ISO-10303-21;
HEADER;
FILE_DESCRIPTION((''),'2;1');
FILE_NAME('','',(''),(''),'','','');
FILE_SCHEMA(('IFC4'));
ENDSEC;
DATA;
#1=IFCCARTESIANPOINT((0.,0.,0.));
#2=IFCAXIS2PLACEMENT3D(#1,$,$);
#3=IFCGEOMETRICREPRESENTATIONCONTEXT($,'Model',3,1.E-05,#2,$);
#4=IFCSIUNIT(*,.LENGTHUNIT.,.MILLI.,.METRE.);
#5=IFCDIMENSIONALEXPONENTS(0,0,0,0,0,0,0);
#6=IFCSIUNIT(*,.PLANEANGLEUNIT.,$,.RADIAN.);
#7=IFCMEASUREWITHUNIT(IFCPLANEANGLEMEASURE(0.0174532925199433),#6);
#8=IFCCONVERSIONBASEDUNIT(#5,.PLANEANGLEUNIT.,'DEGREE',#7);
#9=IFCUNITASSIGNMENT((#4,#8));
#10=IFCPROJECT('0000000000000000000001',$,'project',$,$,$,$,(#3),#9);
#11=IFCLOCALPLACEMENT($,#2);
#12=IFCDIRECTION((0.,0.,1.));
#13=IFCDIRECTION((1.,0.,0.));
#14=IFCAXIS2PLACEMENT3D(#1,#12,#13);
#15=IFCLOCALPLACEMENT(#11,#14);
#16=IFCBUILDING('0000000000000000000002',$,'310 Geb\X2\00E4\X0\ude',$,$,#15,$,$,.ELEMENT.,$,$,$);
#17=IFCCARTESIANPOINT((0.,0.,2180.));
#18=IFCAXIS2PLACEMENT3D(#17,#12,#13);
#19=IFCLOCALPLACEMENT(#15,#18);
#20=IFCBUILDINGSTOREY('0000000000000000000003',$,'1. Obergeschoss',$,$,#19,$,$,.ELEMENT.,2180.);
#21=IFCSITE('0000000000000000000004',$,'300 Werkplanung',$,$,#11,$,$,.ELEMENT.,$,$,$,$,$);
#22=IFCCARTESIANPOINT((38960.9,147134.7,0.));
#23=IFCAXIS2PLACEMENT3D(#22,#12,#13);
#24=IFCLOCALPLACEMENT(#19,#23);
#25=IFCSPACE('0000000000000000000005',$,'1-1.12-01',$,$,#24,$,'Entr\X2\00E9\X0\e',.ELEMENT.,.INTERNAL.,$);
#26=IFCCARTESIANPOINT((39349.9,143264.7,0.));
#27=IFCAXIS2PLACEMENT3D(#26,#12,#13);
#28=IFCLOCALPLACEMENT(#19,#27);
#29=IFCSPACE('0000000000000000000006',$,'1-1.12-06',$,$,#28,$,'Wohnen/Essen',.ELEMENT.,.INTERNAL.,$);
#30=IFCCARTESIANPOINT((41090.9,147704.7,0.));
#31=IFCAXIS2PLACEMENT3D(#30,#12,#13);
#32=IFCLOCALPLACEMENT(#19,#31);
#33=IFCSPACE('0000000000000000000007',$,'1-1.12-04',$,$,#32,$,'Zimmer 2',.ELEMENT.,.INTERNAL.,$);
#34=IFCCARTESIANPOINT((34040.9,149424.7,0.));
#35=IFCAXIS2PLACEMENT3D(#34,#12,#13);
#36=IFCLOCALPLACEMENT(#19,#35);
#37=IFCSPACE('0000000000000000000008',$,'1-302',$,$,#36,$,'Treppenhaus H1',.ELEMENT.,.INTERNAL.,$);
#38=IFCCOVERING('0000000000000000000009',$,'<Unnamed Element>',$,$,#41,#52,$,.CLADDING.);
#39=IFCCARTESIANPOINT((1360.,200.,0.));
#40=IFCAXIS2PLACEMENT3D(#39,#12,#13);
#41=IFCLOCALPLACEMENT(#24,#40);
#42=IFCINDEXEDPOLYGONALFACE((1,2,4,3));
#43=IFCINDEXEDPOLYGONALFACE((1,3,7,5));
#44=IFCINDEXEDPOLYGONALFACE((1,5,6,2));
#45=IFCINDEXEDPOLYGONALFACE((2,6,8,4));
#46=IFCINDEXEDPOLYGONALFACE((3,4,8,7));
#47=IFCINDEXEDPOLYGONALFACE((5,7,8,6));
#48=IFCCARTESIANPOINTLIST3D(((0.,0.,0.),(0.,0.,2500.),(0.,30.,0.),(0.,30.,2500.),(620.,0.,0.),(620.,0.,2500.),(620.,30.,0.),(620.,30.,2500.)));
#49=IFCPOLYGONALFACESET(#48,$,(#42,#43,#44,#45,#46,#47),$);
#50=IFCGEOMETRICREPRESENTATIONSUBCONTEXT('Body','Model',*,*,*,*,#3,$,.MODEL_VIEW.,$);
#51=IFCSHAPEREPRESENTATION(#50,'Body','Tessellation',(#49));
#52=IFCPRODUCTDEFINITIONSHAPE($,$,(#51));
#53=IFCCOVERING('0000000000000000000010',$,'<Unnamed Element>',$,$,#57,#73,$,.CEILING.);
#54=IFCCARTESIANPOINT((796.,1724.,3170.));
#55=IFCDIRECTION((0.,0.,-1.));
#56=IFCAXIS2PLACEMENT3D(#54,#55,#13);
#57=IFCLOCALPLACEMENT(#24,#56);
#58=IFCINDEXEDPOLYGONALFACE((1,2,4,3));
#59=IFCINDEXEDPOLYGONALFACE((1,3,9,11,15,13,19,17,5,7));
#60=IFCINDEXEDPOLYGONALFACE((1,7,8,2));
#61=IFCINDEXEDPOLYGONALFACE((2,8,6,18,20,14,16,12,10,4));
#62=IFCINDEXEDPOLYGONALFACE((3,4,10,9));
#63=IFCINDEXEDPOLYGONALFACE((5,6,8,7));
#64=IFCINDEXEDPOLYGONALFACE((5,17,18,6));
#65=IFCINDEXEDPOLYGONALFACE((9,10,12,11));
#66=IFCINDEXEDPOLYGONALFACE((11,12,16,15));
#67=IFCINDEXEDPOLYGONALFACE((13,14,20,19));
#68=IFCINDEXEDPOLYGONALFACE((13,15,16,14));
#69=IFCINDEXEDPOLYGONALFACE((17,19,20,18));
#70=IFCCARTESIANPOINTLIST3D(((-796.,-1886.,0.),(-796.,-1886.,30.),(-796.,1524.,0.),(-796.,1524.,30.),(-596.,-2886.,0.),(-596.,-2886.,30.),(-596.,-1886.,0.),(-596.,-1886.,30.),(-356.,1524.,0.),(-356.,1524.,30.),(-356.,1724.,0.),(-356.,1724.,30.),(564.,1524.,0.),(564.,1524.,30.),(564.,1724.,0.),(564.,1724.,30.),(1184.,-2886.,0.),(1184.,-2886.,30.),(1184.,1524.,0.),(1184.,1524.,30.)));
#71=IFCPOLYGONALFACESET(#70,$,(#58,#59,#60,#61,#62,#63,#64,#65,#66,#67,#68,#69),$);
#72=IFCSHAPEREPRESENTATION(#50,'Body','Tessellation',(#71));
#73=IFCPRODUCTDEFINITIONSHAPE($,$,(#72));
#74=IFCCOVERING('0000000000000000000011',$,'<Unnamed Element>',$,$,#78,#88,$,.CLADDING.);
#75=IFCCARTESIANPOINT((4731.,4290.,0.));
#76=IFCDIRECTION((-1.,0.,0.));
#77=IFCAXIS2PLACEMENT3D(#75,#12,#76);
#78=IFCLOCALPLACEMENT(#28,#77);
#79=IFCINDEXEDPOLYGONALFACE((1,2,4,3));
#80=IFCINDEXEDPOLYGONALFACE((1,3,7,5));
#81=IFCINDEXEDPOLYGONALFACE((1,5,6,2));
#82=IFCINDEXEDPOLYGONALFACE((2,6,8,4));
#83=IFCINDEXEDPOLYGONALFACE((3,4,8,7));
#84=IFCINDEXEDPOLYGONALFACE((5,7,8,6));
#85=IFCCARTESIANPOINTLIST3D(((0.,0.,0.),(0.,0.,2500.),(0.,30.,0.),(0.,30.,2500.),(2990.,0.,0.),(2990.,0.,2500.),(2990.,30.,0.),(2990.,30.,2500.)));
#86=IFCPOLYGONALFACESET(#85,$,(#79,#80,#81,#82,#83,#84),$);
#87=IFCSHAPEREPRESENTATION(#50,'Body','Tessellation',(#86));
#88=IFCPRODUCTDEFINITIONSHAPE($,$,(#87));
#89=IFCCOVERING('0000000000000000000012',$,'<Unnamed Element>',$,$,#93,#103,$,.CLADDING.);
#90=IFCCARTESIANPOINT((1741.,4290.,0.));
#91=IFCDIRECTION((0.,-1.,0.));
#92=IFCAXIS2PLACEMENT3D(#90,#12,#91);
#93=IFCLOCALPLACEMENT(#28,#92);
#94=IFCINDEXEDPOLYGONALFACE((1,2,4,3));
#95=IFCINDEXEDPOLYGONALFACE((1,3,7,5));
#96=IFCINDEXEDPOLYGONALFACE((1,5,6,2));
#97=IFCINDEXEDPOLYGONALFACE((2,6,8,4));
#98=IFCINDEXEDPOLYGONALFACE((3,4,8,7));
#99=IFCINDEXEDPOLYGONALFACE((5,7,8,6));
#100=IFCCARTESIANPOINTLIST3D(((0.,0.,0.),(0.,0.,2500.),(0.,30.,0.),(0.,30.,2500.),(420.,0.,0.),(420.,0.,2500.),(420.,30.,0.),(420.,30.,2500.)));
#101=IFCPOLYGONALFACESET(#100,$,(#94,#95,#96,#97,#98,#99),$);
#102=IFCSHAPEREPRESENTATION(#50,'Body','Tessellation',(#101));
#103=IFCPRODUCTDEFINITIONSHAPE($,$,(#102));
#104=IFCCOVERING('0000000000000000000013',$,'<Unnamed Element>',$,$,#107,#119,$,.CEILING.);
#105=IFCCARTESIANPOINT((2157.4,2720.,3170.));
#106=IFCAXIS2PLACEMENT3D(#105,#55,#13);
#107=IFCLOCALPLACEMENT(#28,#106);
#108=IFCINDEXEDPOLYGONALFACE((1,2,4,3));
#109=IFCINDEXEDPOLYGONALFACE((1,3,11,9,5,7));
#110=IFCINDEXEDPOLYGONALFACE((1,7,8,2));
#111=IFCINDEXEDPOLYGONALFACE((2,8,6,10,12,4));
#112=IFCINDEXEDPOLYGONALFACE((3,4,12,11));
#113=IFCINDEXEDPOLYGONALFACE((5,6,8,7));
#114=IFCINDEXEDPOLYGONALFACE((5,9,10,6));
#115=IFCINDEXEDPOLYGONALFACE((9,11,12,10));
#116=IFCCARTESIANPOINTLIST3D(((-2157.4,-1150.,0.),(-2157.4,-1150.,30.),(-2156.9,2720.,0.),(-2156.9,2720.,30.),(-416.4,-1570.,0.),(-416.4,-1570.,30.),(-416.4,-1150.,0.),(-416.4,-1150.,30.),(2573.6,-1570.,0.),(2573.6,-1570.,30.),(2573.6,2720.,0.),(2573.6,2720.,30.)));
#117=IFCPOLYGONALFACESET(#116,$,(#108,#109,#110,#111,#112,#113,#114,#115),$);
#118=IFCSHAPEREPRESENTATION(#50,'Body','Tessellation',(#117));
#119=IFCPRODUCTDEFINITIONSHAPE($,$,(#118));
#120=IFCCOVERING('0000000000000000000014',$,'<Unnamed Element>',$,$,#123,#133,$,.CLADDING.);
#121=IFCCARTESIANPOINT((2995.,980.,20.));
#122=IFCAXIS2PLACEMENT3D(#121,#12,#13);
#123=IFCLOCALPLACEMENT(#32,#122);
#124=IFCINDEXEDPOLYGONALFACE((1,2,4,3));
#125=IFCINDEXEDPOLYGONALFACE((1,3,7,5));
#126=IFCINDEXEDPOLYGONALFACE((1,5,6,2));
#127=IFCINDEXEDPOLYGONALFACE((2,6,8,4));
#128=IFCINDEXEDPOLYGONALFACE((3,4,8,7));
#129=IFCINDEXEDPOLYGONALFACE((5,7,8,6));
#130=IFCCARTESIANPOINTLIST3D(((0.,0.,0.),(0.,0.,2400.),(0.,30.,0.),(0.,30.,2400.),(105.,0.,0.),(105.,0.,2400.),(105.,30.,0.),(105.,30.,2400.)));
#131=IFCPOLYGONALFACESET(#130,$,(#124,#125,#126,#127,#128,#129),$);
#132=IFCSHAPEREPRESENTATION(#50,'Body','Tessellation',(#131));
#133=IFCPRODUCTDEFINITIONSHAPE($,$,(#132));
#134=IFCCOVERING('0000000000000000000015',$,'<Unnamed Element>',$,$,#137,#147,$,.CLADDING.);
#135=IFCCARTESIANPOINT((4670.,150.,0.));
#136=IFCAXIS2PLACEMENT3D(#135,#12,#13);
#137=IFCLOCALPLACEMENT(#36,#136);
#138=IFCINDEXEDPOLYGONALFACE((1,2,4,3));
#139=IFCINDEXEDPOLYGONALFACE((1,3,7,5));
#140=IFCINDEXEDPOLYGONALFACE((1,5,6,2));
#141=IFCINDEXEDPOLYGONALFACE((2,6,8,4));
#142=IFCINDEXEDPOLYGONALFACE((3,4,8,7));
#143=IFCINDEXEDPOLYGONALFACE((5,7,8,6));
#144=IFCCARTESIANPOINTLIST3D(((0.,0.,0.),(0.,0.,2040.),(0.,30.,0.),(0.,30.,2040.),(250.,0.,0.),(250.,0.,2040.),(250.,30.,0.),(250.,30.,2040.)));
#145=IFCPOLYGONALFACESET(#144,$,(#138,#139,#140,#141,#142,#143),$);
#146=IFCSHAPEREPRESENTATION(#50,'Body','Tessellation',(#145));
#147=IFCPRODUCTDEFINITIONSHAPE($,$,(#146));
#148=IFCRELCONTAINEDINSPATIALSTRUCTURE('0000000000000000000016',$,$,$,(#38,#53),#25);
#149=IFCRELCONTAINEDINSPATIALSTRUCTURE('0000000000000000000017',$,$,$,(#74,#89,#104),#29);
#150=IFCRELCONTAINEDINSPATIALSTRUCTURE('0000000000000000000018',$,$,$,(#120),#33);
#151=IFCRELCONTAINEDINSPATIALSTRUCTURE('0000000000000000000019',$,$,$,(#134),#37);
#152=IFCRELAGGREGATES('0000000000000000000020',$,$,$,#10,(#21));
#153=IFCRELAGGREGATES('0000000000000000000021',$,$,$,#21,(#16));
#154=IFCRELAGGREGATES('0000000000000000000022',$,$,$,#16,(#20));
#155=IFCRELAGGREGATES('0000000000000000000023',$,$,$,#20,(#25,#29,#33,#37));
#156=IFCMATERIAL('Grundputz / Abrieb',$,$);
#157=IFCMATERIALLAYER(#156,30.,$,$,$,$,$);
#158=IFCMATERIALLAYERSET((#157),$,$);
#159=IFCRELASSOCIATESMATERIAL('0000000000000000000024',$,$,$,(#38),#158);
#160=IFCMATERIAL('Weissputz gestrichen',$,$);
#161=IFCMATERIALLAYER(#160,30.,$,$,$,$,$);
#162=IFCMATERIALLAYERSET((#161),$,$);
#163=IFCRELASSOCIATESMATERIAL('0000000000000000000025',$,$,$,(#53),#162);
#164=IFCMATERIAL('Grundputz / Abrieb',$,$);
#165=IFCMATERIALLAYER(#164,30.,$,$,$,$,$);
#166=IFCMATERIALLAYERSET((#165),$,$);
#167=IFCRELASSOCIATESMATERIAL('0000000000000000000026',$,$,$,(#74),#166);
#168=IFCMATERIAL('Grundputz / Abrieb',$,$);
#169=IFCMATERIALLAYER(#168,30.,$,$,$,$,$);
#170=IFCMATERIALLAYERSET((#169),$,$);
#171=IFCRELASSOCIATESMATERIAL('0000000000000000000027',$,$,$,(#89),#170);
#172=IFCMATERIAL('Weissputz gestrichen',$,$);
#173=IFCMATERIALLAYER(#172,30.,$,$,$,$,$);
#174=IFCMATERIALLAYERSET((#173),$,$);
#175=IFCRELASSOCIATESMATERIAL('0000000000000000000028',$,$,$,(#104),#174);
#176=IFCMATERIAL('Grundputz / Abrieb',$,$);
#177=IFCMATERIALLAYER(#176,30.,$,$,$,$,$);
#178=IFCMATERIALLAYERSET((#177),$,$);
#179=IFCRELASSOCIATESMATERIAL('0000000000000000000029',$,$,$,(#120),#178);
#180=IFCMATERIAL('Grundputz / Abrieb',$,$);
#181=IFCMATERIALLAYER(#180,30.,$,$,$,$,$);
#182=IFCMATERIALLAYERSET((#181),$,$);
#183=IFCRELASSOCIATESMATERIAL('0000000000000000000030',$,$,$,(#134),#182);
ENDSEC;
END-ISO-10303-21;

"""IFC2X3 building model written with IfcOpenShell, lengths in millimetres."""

from ifc_helpers import new_model, entity, si_unit, converted_unit, frame, frame_2d, origin, origin_with_axes, place, context, subcontext, project, spatial, polyline, rectangle, outline, extrude, material, layer, layer_set, layer_usage, element, save


model = new_model("IFC2X3")

# Units and contexts
model_context = context("Model", 3, precision=1e-05, world=origin())
body_context = subcontext(model_context, "Body", "Model", "MODEL_VIEW")
ifc_project = project(units=[si_unit("LENGTHUNIT", "METRE", prefix="MILLI"), converted_unit("PLANEANGLEUNIT", "DEGREE", entity("IfcPlaneAngleMeasure", 0.0174532925199433), si_unit("PLANEANGLEUNIT", "RADIAN"), dimensions=[0, 0, 0, 0, 0, 0, 0])], contexts=[model_context])

# Site, building, storey
site_placement = place(None, origin())
site = spatial("IfcSite", under=ifc_project, at=site_placement, Name="300 Werkplanung", CompositionType="ELEMENT")
building_placement = place(site_placement, origin_with_axes())
building = spatial("IfcBuilding", under=site, at=building_placement, Name="310 Gebäude", CompositionType="ELEMENT")
storey_placement = place(building_placement, frame((0.0, 0.0, 2180.0), z_axis=(0.0, 0.0, 1.0), x_axis=(1.0, 0.0, 0.0)))
storey = spatial("IfcBuildingStorey", under=building, at=storey_placement, Name="1. Obergeschoss", CompositionType="ELEMENT", Elevation=2180.0)

# Shared definitions
space_1_placement = place(storey_placement, frame((38960.9, 147134.7, 0.0), z_axis=(0.0, 0.0, 1.0), x_axis=(1.0, 0.0, 0.0)))
space_1 = spatial("IfcSpace", under=storey, at=space_1_placement, Name="1-1.12-01", LongName="Entrée", CompositionType="ELEMENT", InteriorOrExteriorSpace="INTERNAL")

# Coverings
ifc_material_1 = material(Name="Grundputz / Abrieb")
ifc_layer_1 = layer(ifc_material_1, 30.0)
ifc_layer_set_1 = layer_set([ifc_layer_1])
ifc_layer_usage_1 = layer_usage(ifc_layer_set_1, "AXIS3", "POSITIVE", 0.0)
covering_1_placement = place(space_1_placement, frame((1360.0, 200.0, 0.0), z_axis=(0.0, 0.0, 1.0), x_axis=(1.0, 0.0, 0.0)))
element("IfcCovering", 1, at=covering_1_placement, inside=space_1, material=ifc_layer_usage_1, Name="<Unnamed Element>", PredefinedType="CLADDING", context=body_context, shape_type="SweptSolid", body=[
    extrude(rectangle(XDim=2500.0, YDim=620.0, at=frame_2d((-310.0, 1250.0), x_axis=(0.0, 1.0))), frame((620.0, 0.0, 2500.0), z_axis=(0.0, 1.0, 0.0), x_axis=(1.0, 0.0, 0.0)), (0.0, 0.0, 1.0), 30.0),
])
ifc_material_2 = material(Name="Weissputz gestrichen")
ifc_layer_2 = layer(ifc_material_2, 30.0)
ifc_layer_set_2 = layer_set([ifc_layer_2])
ifc_layer_usage_2 = layer_usage(ifc_layer_set_2, "AXIS3", "POSITIVE", 0.0)
covering_2_placement = place(space_1_placement, frame((796.0, 1724.0, 3170.0), z_axis=(0.0, 0.0, -1.0), x_axis=(1.0, 0.0, 0.0)))
element("IfcCovering", 2, at=covering_2_placement, inside=space_1, material=ifc_layer_usage_2, Name="<Unnamed Element>", PredefinedType="CEILING", context=body_context, shape_type="SweptSolid", body=[
    extrude(outline(polyline([(-796.0, 1524.0), (-796.0, -1886.0), (-596.0, -1886.0), (-596.0, -2886.0), (1184.0, -2886.0), (1184.0, 1524.0), (564.0, 1524.0), (564.0, 1724.0), (-356.0, 1724.0), (-356.0, 1524.0), (-796.0, 1524.0)])), origin_with_axes(), (0.0, 0.0, 1.0), 30.0),
])

# Shared definitions
space_2_placement = place(storey_placement, frame((39349.9, 143264.7, 0.0), z_axis=(0.0, 0.0, 1.0), x_axis=(1.0, 0.0, 0.0)))
space_2 = spatial("IfcSpace", under=storey, at=space_2_placement, Name="1-1.12-06", LongName="Wohnen/Essen", CompositionType="ELEMENT", InteriorOrExteriorSpace="INTERNAL")

# Coverings
ifc_material_3 = material(Name="Grundputz / Abrieb")
ifc_layer_3 = layer(ifc_material_3, 30.0)
ifc_layer_set_3 = layer_set([ifc_layer_3])
ifc_layer_usage_3 = layer_usage(ifc_layer_set_3, "AXIS3", "POSITIVE", 0.0)
covering_3_placement = place(space_2_placement, frame((4731.0, 4290.0, 0.0), z_axis=(0.0, 0.0, 1.0), x_axis=(-1.0, 0.0, 0.0)))
element("IfcCovering", 3, at=covering_3_placement, inside=space_2, material=ifc_layer_usage_3, Name="<Unnamed Element>", PredefinedType="CLADDING", context=body_context, shape_type="SweptSolid", body=[
    extrude(rectangle(XDim=2500.0, YDim=2990.0, at=frame_2d((-1495.0, 1250.0), x_axis=(0.0, 1.0))), frame((2990.0, 0.0, 2500.0), z_axis=(0.0, 1.0, 0.0), x_axis=(1.0, 0.0, 0.0)), (0.0, 0.0, 1.0), 30.0),
])
ifc_material_4 = material(Name="Grundputz / Abrieb")
ifc_layer_4 = layer(ifc_material_4, 30.0)
ifc_layer_set_4 = layer_set([ifc_layer_4])
ifc_layer_usage_4 = layer_usage(ifc_layer_set_4, "AXIS3", "POSITIVE", 0.0)
covering_4_placement = place(space_2_placement, frame((1741.0, 4290.0, 0.0), z_axis=(0.0, 0.0, 1.0), x_axis=(0.0, -1.0, 0.0)))
element("IfcCovering", 4, at=covering_4_placement, inside=space_2, material=ifc_layer_usage_4, Name="<Unnamed Element>", PredefinedType="CLADDING", context=body_context, shape_type="SweptSolid", body=[
    extrude(rectangle(XDim=2500.0, YDim=420.0, at=frame_2d((-210.0, 1250.0), x_axis=(0.0, 1.0))), frame((420.0, 0.0, 2500.0), z_axis=(0.0, 1.0, 0.0), x_axis=(1.0, 0.0, 0.0)), (0.0, 0.0, 1.0), 30.0),
])
ifc_material_5 = material(Name="Weissputz gestrichen")
ifc_layer_5 = layer(ifc_material_5, 30.0)
ifc_layer_set_5 = layer_set([ifc_layer_5])
ifc_layer_usage_5 = layer_usage(ifc_layer_set_5, "AXIS3", "POSITIVE", 0.0)
covering_5_placement = place(space_2_placement, frame((2157.4, 2720.0, 3170.0), z_axis=(0.0, 0.0, -1.0), x_axis=(1.0, 0.0, 0.0)))
element("IfcCovering", 5, at=covering_5_placement, inside=space_2, material=ifc_layer_usage_5, Name="<Unnamed Element>", PredefinedType="CEILING", context=body_context, shape_type="SweptSolid", body=[
    extrude(outline(polyline([(-2157.4, -1150.0), (-416.4, -1150.0), (-416.4, -1570.0), (2573.6, -1570.0), (2573.6, 2720.0), (-2156.9, 2720.0), (-2157.4, -1150.0)])), origin_with_axes(), (0.0, 0.0, 1.0), 30.0),
])

# Shared definitions
space_3_placement = place(storey_placement, frame((41090.9, 147704.7, 0.0), z_axis=(0.0, 0.0, 1.0), x_axis=(1.0, 0.0, 0.0)))
space_3 = spatial("IfcSpace", under=storey, at=space_3_placement, Name="1-1.12-04", LongName="Zimmer 2", CompositionType="ELEMENT", InteriorOrExteriorSpace="INTERNAL")

# Covering
ifc_material_6 = material(Name="Grundputz / Abrieb")
ifc_layer_6 = layer(ifc_material_6, 30.0)
ifc_layer_set_6 = layer_set([ifc_layer_6])
ifc_layer_usage_6 = layer_usage(ifc_layer_set_6, "AXIS3", "POSITIVE", 0.0)
covering_6_placement = place(space_3_placement, frame((2995.0, 980.0, 20.0), z_axis=(0.0, 0.0, 1.0), x_axis=(1.0, 0.0, 0.0)))
element("IfcCovering", 6, at=covering_6_placement, inside=space_3, material=ifc_layer_usage_6, Name="<Unnamed Element>", PredefinedType="CLADDING", context=body_context, shape_type="SweptSolid", body=[
    extrude(rectangle(XDim=2400.0, YDim=105.0, at=frame_2d((-52.5, 1200.0), x_axis=(0.0, 1.0))), frame((105.0, 0.0, 2400.0), z_axis=(0.0, 1.0, 0.0), x_axis=(1.0, 0.0, 0.0)), (0.0, 0.0, 1.0), 30.0),
])

# Shared definitions
space_4_placement = place(storey_placement, frame((34040.9, 149424.7, 0.0), z_axis=(0.0, 0.0, 1.0), x_axis=(1.0, 0.0, 0.0)))
space_4 = spatial("IfcSpace", under=storey, at=space_4_placement, Name="1-302", LongName="Treppenhaus H1", CompositionType="ELEMENT", InteriorOrExteriorSpace="INTERNAL")

# Covering
ifc_material_7 = material(Name="Grundputz / Abrieb")
ifc_layer_7 = layer(ifc_material_7, 30.0)
ifc_layer_set_7 = layer_set([ifc_layer_7])
ifc_layer_usage_7 = layer_usage(ifc_layer_set_7, "AXIS3", "POSITIVE", 0.0)
covering_7_placement = place(space_4_placement, frame((4670.0, 150.0, 0.0), z_axis=(0.0, 0.0, 1.0), x_axis=(1.0, 0.0, 0.0)))
element("IfcCovering", 7, at=covering_7_placement, inside=space_4, material=ifc_layer_usage_7, Name="<Unnamed Element>", PredefinedType="CLADDING", context=body_context, shape_type="SweptSolid", body=[
    extrude(rectangle(XDim=2040.0, YDim=250.0, at=frame_2d((-125.0, 1020.0), x_axis=(0.0, 1.0))), frame((250.0, 0.0, 2040.0), z_axis=(0.0, 1.0, 0.0), x_axis=(1.0, 0.0, 0.0)), (0.0, 0.0, 1.0), 30.0),
])

save(model, "model.ifc")
